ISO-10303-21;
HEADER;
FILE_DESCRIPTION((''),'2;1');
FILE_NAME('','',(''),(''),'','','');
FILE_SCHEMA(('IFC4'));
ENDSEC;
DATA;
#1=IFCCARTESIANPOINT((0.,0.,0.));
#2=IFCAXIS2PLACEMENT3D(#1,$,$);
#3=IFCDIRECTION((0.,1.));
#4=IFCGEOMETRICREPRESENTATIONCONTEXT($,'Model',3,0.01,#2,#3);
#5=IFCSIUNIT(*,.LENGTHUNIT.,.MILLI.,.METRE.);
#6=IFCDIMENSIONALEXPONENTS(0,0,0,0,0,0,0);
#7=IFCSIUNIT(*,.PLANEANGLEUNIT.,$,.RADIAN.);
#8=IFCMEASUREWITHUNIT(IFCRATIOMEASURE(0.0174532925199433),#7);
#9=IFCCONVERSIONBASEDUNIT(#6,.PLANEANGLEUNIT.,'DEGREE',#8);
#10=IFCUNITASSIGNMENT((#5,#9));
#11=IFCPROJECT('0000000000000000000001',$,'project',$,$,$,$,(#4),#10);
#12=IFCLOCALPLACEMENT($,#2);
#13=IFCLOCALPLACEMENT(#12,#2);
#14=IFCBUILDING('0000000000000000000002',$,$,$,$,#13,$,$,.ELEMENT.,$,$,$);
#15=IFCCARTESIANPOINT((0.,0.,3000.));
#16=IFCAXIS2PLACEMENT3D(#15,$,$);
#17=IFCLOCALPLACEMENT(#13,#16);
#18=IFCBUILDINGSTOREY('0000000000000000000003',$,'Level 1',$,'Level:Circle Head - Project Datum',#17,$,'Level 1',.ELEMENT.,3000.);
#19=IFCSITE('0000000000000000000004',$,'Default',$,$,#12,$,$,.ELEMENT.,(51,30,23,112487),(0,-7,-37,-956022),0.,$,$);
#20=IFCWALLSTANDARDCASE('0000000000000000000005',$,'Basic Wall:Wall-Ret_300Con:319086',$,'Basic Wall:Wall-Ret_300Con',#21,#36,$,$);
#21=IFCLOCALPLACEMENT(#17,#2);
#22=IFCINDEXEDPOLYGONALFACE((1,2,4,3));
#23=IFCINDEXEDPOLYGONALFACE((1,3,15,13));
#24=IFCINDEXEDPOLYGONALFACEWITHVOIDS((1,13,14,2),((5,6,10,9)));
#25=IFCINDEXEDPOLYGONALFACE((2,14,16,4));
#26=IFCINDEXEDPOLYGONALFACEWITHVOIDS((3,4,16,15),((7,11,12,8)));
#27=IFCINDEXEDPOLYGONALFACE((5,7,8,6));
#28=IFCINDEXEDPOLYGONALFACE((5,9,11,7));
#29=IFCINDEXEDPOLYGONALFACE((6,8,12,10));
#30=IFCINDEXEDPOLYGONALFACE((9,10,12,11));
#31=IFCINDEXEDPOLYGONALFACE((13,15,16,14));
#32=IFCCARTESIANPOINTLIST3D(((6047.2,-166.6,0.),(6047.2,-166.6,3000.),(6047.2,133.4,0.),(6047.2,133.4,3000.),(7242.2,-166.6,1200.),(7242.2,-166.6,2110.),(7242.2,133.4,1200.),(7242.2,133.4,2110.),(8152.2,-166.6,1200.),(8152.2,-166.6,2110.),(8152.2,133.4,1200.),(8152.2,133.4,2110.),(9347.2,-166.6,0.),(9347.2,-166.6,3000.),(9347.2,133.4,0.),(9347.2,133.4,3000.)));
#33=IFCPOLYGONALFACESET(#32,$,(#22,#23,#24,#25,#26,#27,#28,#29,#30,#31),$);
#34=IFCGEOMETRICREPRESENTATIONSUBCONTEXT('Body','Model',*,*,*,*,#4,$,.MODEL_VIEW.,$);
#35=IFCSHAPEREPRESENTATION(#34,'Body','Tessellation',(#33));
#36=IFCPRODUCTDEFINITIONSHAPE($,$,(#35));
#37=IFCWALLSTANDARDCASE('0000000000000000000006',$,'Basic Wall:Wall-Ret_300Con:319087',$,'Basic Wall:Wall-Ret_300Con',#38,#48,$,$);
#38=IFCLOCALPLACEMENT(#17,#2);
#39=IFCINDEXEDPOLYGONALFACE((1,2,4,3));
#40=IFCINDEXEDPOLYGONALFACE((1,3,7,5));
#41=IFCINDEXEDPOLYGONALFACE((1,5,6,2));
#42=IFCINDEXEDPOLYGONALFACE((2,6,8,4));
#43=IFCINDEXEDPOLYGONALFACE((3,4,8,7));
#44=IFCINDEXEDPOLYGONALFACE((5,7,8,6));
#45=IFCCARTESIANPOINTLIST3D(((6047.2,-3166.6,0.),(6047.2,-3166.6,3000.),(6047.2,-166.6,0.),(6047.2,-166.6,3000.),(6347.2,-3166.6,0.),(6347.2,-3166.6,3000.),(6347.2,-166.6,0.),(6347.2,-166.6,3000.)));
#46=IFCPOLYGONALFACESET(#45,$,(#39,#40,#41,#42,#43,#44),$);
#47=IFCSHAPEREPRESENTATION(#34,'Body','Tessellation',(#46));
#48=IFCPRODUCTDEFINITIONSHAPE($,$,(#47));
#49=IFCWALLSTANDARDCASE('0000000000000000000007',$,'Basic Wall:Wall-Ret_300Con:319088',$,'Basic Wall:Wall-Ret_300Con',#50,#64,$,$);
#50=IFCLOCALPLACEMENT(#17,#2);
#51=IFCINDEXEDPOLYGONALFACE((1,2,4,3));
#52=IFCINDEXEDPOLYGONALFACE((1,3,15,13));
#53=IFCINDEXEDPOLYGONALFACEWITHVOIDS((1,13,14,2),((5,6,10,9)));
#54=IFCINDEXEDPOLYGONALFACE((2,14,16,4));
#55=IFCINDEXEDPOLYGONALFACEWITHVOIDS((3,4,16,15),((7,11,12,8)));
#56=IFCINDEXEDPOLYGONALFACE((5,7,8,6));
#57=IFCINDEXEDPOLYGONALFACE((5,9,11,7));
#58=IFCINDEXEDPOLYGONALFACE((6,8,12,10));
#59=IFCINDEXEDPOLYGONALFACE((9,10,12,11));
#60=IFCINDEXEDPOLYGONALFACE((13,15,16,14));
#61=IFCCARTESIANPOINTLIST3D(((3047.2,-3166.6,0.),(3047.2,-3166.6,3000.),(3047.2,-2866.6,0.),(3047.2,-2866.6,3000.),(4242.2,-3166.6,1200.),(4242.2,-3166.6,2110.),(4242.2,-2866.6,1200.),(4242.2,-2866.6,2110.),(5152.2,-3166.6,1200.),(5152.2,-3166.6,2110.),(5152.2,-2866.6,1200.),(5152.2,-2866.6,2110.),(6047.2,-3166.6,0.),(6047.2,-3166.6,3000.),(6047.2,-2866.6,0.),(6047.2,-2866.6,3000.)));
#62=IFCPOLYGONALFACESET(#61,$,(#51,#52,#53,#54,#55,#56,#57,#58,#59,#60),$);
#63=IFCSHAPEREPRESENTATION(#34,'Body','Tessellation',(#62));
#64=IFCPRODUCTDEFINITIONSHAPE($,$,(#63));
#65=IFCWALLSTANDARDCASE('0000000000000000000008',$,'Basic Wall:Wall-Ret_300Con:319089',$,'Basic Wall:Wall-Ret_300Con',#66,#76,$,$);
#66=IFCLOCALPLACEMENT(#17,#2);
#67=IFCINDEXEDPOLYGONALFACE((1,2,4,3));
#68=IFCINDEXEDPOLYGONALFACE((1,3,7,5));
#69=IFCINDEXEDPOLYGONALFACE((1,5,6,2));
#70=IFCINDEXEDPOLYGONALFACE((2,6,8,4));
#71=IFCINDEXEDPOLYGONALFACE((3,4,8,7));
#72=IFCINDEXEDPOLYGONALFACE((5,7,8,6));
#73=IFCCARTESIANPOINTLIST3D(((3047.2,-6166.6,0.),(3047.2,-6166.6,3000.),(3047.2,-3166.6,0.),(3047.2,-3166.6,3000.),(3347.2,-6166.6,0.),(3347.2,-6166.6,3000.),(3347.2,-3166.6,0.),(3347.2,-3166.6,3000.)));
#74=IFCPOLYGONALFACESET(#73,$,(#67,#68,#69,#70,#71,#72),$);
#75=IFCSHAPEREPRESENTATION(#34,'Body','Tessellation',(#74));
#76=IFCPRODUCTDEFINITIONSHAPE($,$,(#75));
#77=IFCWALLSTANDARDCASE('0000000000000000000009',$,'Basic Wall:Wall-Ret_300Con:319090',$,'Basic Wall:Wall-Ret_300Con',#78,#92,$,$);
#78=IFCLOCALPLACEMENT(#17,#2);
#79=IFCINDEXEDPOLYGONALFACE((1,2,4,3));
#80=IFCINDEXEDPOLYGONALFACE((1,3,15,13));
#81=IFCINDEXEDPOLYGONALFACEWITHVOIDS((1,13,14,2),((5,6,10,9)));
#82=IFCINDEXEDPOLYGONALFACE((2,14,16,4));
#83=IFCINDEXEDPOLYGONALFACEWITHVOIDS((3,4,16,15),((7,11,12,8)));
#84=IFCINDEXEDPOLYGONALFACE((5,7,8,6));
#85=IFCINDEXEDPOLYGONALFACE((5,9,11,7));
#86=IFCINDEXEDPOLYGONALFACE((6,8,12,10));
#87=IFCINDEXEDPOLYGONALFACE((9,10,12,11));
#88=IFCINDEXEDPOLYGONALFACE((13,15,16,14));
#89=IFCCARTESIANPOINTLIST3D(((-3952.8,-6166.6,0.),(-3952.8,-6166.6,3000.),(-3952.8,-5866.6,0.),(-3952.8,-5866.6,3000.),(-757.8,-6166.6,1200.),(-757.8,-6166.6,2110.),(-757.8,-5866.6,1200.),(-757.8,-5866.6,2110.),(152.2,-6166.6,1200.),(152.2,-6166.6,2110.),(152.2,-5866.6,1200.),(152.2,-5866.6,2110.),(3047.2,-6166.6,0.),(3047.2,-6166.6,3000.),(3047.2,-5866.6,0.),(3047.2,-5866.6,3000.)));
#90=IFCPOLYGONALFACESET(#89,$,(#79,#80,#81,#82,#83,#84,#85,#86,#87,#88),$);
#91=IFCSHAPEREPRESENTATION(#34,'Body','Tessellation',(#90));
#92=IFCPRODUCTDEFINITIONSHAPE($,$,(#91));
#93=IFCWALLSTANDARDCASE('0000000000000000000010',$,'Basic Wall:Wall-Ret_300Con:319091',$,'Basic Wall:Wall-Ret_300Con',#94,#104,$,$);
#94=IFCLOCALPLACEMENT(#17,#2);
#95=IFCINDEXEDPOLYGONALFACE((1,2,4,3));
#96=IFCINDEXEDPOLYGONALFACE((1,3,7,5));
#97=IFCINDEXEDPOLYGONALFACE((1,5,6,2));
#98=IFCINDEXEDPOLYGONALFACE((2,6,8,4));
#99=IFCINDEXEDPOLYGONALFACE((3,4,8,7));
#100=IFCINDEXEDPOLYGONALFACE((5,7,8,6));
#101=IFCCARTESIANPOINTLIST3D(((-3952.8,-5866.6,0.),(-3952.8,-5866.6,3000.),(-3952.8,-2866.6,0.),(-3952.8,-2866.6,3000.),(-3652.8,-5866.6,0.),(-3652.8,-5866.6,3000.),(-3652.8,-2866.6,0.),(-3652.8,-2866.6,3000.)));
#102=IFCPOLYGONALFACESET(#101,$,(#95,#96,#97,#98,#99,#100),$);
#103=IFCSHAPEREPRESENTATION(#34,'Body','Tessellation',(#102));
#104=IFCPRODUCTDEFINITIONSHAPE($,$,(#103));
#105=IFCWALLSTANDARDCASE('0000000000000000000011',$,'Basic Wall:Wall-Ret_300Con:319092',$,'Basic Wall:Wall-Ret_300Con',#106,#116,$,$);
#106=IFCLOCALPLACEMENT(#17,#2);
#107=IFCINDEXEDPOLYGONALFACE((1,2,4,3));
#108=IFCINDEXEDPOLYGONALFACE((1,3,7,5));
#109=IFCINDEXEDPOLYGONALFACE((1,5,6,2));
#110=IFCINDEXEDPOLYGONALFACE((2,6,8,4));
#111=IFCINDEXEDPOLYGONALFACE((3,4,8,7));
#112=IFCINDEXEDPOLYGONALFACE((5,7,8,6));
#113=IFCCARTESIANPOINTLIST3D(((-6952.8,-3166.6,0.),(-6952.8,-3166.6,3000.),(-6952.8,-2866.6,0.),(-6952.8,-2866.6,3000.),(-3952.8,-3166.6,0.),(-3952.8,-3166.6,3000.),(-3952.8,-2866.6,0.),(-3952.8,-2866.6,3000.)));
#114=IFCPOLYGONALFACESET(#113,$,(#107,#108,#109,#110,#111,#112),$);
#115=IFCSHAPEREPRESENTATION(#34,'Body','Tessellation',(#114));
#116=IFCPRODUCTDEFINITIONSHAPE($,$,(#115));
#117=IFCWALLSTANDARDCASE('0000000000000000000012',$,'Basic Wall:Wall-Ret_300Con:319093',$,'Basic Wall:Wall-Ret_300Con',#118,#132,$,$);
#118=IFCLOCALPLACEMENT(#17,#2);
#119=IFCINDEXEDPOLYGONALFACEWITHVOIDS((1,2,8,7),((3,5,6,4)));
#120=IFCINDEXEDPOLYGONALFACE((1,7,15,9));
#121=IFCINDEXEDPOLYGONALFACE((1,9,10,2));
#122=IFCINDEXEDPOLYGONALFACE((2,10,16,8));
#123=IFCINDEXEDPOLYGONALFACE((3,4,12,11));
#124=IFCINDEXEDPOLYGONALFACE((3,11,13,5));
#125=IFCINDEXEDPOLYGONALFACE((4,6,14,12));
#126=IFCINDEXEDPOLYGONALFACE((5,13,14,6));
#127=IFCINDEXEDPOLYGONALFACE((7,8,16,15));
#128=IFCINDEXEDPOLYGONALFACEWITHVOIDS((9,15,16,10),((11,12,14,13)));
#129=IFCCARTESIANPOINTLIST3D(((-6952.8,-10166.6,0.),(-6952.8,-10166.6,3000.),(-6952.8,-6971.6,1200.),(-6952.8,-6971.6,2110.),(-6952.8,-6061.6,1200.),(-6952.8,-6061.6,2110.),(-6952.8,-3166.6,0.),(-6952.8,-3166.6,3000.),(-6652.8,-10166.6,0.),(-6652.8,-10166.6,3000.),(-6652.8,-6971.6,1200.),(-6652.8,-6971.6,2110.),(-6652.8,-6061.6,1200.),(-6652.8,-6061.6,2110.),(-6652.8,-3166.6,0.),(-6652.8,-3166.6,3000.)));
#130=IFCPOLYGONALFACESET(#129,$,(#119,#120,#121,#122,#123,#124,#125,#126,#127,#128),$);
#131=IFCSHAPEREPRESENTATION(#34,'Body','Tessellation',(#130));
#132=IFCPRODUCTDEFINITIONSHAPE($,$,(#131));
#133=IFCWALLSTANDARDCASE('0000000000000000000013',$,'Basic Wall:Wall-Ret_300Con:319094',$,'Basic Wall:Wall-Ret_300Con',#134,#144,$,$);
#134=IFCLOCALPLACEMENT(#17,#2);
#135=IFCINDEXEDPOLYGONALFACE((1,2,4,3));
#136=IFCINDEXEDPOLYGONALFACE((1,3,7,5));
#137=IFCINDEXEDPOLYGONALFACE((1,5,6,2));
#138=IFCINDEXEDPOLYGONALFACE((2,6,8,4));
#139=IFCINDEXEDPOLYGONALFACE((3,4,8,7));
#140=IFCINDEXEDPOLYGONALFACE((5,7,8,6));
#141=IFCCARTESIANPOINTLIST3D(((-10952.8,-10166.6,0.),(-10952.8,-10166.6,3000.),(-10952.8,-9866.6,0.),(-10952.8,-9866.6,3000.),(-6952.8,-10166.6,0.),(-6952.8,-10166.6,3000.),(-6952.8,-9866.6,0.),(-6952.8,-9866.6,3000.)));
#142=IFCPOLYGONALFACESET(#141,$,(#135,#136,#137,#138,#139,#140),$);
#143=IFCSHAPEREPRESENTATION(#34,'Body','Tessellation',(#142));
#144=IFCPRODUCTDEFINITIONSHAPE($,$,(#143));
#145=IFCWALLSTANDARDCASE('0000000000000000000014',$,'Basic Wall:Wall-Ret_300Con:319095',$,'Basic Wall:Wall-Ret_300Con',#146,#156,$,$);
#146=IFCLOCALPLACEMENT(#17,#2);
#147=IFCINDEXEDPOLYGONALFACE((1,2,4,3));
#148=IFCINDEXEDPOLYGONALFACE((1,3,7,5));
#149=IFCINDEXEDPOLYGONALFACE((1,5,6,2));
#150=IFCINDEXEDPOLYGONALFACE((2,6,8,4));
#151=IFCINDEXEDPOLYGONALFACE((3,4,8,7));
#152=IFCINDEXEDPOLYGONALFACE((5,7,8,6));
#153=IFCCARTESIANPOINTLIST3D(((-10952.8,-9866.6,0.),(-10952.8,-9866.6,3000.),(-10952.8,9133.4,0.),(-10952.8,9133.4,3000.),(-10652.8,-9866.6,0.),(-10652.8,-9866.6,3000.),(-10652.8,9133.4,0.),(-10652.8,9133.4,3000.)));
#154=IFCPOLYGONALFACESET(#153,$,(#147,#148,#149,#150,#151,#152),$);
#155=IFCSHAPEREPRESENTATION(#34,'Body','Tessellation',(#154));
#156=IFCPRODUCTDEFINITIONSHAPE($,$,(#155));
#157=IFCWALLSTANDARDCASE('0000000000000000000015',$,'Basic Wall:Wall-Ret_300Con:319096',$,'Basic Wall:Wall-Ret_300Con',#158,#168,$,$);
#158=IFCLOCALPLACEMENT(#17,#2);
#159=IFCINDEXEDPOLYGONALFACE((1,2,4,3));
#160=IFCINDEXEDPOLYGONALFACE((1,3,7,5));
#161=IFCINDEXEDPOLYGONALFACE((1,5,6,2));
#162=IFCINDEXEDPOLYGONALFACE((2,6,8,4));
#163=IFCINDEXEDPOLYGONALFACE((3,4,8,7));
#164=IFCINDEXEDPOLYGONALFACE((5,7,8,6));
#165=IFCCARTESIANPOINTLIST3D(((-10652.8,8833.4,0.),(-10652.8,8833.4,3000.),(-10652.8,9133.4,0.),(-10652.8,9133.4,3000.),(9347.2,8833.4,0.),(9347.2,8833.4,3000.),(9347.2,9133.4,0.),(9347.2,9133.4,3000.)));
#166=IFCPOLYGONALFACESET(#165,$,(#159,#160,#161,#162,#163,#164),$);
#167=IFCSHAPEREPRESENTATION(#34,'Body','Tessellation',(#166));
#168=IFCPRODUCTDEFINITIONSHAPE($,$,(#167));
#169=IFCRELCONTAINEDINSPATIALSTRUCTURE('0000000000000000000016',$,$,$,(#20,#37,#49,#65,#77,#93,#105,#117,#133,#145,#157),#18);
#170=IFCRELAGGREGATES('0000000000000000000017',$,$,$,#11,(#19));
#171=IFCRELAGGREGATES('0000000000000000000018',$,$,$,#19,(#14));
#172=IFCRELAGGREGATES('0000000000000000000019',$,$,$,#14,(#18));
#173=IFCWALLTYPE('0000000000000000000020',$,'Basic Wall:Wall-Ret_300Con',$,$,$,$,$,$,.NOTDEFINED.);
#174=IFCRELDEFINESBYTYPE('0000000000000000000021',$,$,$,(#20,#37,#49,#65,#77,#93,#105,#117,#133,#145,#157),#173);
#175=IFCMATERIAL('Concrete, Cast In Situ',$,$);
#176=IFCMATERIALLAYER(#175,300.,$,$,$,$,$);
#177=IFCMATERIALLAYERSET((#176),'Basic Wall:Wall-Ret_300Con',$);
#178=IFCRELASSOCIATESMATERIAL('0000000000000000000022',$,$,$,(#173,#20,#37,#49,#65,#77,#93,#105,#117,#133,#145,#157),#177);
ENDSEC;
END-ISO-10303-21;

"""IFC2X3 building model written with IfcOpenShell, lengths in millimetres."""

from ifc_helpers import new_model, entity, si_unit, converted_unit, direction, frame, frame_2d, origin, place, context, subcontext, project, spatial, rectangle, extrude, material, layer, layer_set, layer_usage, type_object, element, save


model = new_model("IFC2X3")

# Units and contexts
model_context = context("Model", 3, precision=0.01, world=origin(), true_north=direction((0.0, 1.0)))
body_context = subcontext(model_context, "Body", "Model", "MODEL_VIEW")
ifc_project = project(units=[si_unit("LENGTHUNIT", "METRE", prefix="MILLI"), converted_unit("PLANEANGLEUNIT", "DEGREE", entity("IfcRatioMeasure", 0.0174532925199433), si_unit("PLANEANGLEUNIT", "RADIAN"), dimensions=[0, 0, 0, 0, 0, 0, 0])], contexts=[model_context])

# Site, building, storey
site_placement = place(None, origin())
site = spatial("IfcSite", under=ifc_project, at=site_placement, Name="Default", CompositionType="ELEMENT", RefLatitude=(51, 30, 23, 112487), RefLongitude=(0, -7, -37, -956022), RefElevation=0.0)
building_placement = place(site_placement, origin())
building = spatial("IfcBuilding", under=site, at=building_placement, CompositionType="ELEMENT")
storey_placement = place(building_placement, frame((0.0, 0.0, 3000.0)))
storey = spatial("IfcBuildingStorey", under=building, at=storey_placement, Name="Level 1", ObjectType="Level:Circle Head - Project Datum", LongName="Level 1", CompositionType="ELEMENT", Elevation=3000.0)

# Wall, opening
ifc_material_1 = material(Name="Concrete, Cast In Situ")
ifc_layer_1 = layer(ifc_material_1, 300.0)
ifc_layer_set_1 = layer_set([ifc_layer_1], Name="Basic Wall:Wall-Ret_300Con")
ifc_layer_usage_1 = layer_usage(ifc_layer_set_1, "AXIS2", "NEGATIVE", 150.0)
wall_type = type_object("IfcWallType", Name="Basic Wall:Wall-Ret_300Con", PredefinedType="NOTDEFINED", material=ifc_layer_set_1)
wall_1_placement = place(storey_placement, frame((9347.2, -16.6, 0.0), z_axis=(0.0, 0.0, 1.0), x_axis=(-1.0, 0.0, 0.0)))
wall_1 = element("IfcWallStandardCase", 1, at=wall_1_placement, inside=storey, type_object=wall_type, material=ifc_layer_usage_1, Name="Basic Wall:Wall-Ret_300Con:319086", ObjectType="Basic Wall:Wall-Ret_300Con", context=body_context, shape_type="SweptSolid", body=[
    extrude(rectangle(XDim=3300.0, YDim=300.0, at=frame_2d((1650.0, 0.0), x_axis=(-1.0, 0.0))), origin(), (0.0, 0.0, 1.0), 3000.0),
])
opening_1_placement = place(wall_1_placement, frame((1195.0, -150.0, 1200.0)))
element("IfcOpeningElement", 2, at=opening_1_placement, cuts=wall_1, ObjectType="Opening", context=body_context, shape_type="SweptSolid", body=[
    extrude(rectangle(XDim=910.0, YDim=910.0, at=frame_2d((455.0, 455.0), x_axis=(-1.0, 0.0))), frame((0.0, 0.0, 0.0), z_axis=(0.0, 1.0, 0.0), x_axis=(0.0, 0.0, 1.0)), (0.0, 0.0, 1.0), 300.0),
])

# Wall
ifc_layer_usage_2 = layer_usage(ifc_layer_set_1, "AXIS2", "NEGATIVE", 150.0)
wall_2_placement = place(storey_placement, frame((6197.2, -166.6, 0.0), z_axis=(0.0, 0.0, 1.0), x_axis=(0.0, -1.0, 0.0)))
element("IfcWallStandardCase", 3, at=wall_2_placement, inside=storey, type_object=wall_type, material=ifc_layer_usage_2, Name="Basic Wall:Wall-Ret_300Con:319087", ObjectType="Basic Wall:Wall-Ret_300Con", context=body_context, shape_type="SweptSolid", body=[
    extrude(rectangle(XDim=3000.0, YDim=300.0, at=frame_2d((1500.0, 0.0), x_axis=(-1.0, 0.0))), origin(), (0.0, 0.0, 1.0), 3000.0),
])

# Wall, opening
ifc_layer_usage_3 = layer_usage(ifc_layer_set_1, "AXIS2", "NEGATIVE", 150.0)
wall_3_placement = place(storey_placement, frame((6047.2, -3016.6, 0.0), z_axis=(0.0, 0.0, 1.0), x_axis=(-1.0, 0.0, 0.0)))
wall_3 = element("IfcWallStandardCase", 4, at=wall_3_placement, inside=storey, type_object=wall_type, material=ifc_layer_usage_3, Name="Basic Wall:Wall-Ret_300Con:319088", ObjectType="Basic Wall:Wall-Ret_300Con", context=body_context, shape_type="SweptSolid", body=[
    extrude(rectangle(XDim=3000.0, YDim=300.0, at=frame_2d((1500.0, 0.0), x_axis=(-1.0, 0.0))), origin(), (0.0, 0.0, 1.0), 3000.0),
])
opening_2_placement = place(wall_3_placement, frame((895.0, -150.0, 1200.0)))
element("IfcOpeningElement", 5, at=opening_2_placement, cuts=wall_3, ObjectType="Opening", context=body_context, shape_type="SweptSolid", body=[
    extrude(rectangle(XDim=910.0, YDim=910.0, at=frame_2d((455.0, 455.0), x_axis=(-1.0, 0.0))), frame((0.0, 0.0, 0.0), z_axis=(0.0, 1.0, 0.0), x_axis=(0.0, 0.0, 1.0)), (0.0, 0.0, 1.0), 300.0),
])

# Wall
ifc_layer_usage_4 = layer_usage(ifc_layer_set_1, "AXIS2", "NEGATIVE", 150.0)
wall_4_placement = place(storey_placement, frame((3197.2, -3166.6, 0.0), z_axis=(0.0, 0.0, 1.0), x_axis=(0.0, -1.0, 0.0)))
element("IfcWallStandardCase", 6, at=wall_4_placement, inside=storey, type_object=wall_type, material=ifc_layer_usage_4, Name="Basic Wall:Wall-Ret_300Con:319089", ObjectType="Basic Wall:Wall-Ret_300Con", context=body_context, shape_type="SweptSolid", body=[
    extrude(rectangle(XDim=3000.0, YDim=300.0, at=frame_2d((1500.0, 0.0), x_axis=(-1.0, 0.0))), origin(), (0.0, 0.0, 1.0), 3000.0),
])

# Wall, opening
ifc_layer_usage_5 = layer_usage(ifc_layer_set_1, "AXIS2", "NEGATIVE", 150.0)
wall_5_placement = place(storey_placement, frame((3047.2, -6016.6, 0.0), z_axis=(0.0, 0.0, 1.0), x_axis=(-1.0, 0.0, 0.0)))
wall_5 = element("IfcWallStandardCase", 7, at=wall_5_placement, inside=storey, type_object=wall_type, material=ifc_layer_usage_5, Name="Basic Wall:Wall-Ret_300Con:319090", ObjectType="Basic Wall:Wall-Ret_300Con", context=body_context, shape_type="SweptSolid", body=[
    extrude(rectangle(XDim=7000.0, YDim=300.0, at=frame_2d((3500.0, 0.0), x_axis=(-1.0, 0.0))), origin(), (0.0, 0.0, 1.0), 3000.0),
])
opening_3_placement = place(wall_5_placement, frame((2895.0, -150.0, 1200.0)))
element("IfcOpeningElement", 8, at=opening_3_placement, cuts=wall_5, ObjectType="Opening", context=body_context, shape_type="SweptSolid", body=[
    extrude(rectangle(XDim=910.0, YDim=910.0, at=frame_2d((455.0, 455.0), x_axis=(-1.0, 0.0))), frame((0.0, 0.0, 0.0), z_axis=(0.0, 1.0, 0.0), x_axis=(0.0, 0.0, 1.0)), (0.0, 0.0, 1.0), 300.0),
])

# Walls
ifc_layer_usage_6 = layer_usage(ifc_layer_set_1, "AXIS2", "NEGATIVE", 150.0)
wall_6_placement = place(storey_placement, frame((-3802.8, -5866.6, 0.0), z_axis=(0.0, 0.0, 1.0), x_axis=(0.0, 1.0, 0.0)))
element("IfcWallStandardCase", 9, at=wall_6_placement, inside=storey, type_object=wall_type, material=ifc_layer_usage_6, Name="Basic Wall:Wall-Ret_300Con:319091", ObjectType="Basic Wall:Wall-Ret_300Con", context=body_context, shape_type="SweptSolid", body=[
    extrude(rectangle(XDim=3000.0, YDim=300.0, at=frame_2d((1500.0, 0.0), x_axis=(-1.0, 0.0))), origin(), (0.0, 0.0, 1.0), 3000.0),
])
ifc_layer_usage_7 = layer_usage(ifc_layer_set_1, "AXIS2", "NEGATIVE", 150.0)
wall_7_placement = place(storey_placement, frame((-3952.8, -3016.6, 0.0), z_axis=(0.0, 0.0, 1.0), x_axis=(-1.0, 0.0, 0.0)))
element("IfcWallStandardCase", 10, at=wall_7_placement, inside=storey, type_object=wall_type, material=ifc_layer_usage_7, Name="Basic Wall:Wall-Ret_300Con:319092", ObjectType="Basic Wall:Wall-Ret_300Con", context=body_context, shape_type="SweptSolid", body=[
    extrude(rectangle(XDim=3000.0, YDim=300.0, at=frame_2d((1500.0, 0.0), x_axis=(-1.0, 0.0))), origin(), (0.0, 0.0, 1.0), 3000.0),
])

# Wall, opening
ifc_layer_usage_8 = layer_usage(ifc_layer_set_1, "AXIS2", "NEGATIVE", 150.0)
wall_8_placement = place(storey_placement, frame((-6802.8, -3166.6, 0.0), z_axis=(0.0, 0.0, 1.0), x_axis=(0.0, -1.0, 0.0)))
wall_8 = element("IfcWallStandardCase", 11, at=wall_8_placement, inside=storey, type_object=wall_type, material=ifc_layer_usage_8, Name="Basic Wall:Wall-Ret_300Con:319093", ObjectType="Basic Wall:Wall-Ret_300Con", context=body_context, shape_type="SweptSolid", body=[
    extrude(rectangle(XDim=7000.0, YDim=300.0, at=frame_2d((3500.0, 0.0), x_axis=(-1.0, 0.0))), origin(), (0.0, 0.0, 1.0), 3000.0),
])
opening_4_placement = place(wall_8_placement, frame((2895.0, -150.0, 1200.0)))
element("IfcOpeningElement", 12, at=opening_4_placement, cuts=wall_8, ObjectType="Opening", context=body_context, shape_type="SweptSolid", body=[
    extrude(rectangle(XDim=910.0, YDim=910.0, at=frame_2d((455.0, 455.0), x_axis=(-1.0, 0.0))), frame((0.0, 0.0, 0.0), z_axis=(0.0, 1.0, 0.0), x_axis=(0.0, 0.0, 1.0)), (0.0, 0.0, 1.0), 300.0),
])

# Walls
ifc_layer_usage_9 = layer_usage(ifc_layer_set_1, "AXIS2", "NEGATIVE", 150.0)
wall_9_placement = place(storey_placement, frame((-6952.8, -10016.6, 0.0), z_axis=(0.0, 0.0, 1.0), x_axis=(-1.0, 0.0, 0.0)))
element("IfcWallStandardCase", 13, at=wall_9_placement, inside=storey, type_object=wall_type, material=ifc_layer_usage_9, Name="Basic Wall:Wall-Ret_300Con:319094", ObjectType="Basic Wall:Wall-Ret_300Con", context=body_context, shape_type="SweptSolid", body=[
    extrude(rectangle(XDim=4000.0, YDim=300.0, at=frame_2d((2000.0, 0.0), x_axis=(-1.0, 0.0))), origin(), (0.0, 0.0, 1.0), 3000.0),
])
ifc_layer_usage_10 = layer_usage(ifc_layer_set_1, "AXIS2", "NEGATIVE", 150.0)
wall_10_placement = place(storey_placement, frame((-10802.8, -9866.6, 0.0), z_axis=(0.0, 0.0, 1.0), x_axis=(0.0, 1.0, 0.0)))
element("IfcWallStandardCase", 14, at=wall_10_placement, inside=storey, type_object=wall_type, material=ifc_layer_usage_10, Name="Basic Wall:Wall-Ret_300Con:319095", ObjectType="Basic Wall:Wall-Ret_300Con", context=body_context, shape_type="SweptSolid", body=[
    extrude(rectangle(XDim=19000.0, YDim=300.0, at=frame_2d((9500.0, 0.0), x_axis=(-1.0, 0.0))), origin(), (0.0, 0.0, 1.0), 3000.0),
])
ifc_layer_usage_11 = layer_usage(ifc_layer_set_1, "AXIS2", "NEGATIVE", 150.0)
wall_11_placement = place(storey_placement, frame((-10652.8, 8983.4, 0.0)))
element("IfcWallStandardCase", 15, at=wall_11_placement, inside=storey, type_object=wall_type, material=ifc_layer_usage_11, Name="Basic Wall:Wall-Ret_300Con:319096", ObjectType="Basic Wall:Wall-Ret_300Con", context=body_context, shape_type="SweptSolid", body=[
    extrude(rectangle(XDim=20000.0, YDim=300.0, at=frame_2d((10000.0, 0.0), x_axis=(-1.0, 0.0))), origin(), (0.0, 0.0, 1.0), 3000.0),
])

save(model, "model.ifc")
